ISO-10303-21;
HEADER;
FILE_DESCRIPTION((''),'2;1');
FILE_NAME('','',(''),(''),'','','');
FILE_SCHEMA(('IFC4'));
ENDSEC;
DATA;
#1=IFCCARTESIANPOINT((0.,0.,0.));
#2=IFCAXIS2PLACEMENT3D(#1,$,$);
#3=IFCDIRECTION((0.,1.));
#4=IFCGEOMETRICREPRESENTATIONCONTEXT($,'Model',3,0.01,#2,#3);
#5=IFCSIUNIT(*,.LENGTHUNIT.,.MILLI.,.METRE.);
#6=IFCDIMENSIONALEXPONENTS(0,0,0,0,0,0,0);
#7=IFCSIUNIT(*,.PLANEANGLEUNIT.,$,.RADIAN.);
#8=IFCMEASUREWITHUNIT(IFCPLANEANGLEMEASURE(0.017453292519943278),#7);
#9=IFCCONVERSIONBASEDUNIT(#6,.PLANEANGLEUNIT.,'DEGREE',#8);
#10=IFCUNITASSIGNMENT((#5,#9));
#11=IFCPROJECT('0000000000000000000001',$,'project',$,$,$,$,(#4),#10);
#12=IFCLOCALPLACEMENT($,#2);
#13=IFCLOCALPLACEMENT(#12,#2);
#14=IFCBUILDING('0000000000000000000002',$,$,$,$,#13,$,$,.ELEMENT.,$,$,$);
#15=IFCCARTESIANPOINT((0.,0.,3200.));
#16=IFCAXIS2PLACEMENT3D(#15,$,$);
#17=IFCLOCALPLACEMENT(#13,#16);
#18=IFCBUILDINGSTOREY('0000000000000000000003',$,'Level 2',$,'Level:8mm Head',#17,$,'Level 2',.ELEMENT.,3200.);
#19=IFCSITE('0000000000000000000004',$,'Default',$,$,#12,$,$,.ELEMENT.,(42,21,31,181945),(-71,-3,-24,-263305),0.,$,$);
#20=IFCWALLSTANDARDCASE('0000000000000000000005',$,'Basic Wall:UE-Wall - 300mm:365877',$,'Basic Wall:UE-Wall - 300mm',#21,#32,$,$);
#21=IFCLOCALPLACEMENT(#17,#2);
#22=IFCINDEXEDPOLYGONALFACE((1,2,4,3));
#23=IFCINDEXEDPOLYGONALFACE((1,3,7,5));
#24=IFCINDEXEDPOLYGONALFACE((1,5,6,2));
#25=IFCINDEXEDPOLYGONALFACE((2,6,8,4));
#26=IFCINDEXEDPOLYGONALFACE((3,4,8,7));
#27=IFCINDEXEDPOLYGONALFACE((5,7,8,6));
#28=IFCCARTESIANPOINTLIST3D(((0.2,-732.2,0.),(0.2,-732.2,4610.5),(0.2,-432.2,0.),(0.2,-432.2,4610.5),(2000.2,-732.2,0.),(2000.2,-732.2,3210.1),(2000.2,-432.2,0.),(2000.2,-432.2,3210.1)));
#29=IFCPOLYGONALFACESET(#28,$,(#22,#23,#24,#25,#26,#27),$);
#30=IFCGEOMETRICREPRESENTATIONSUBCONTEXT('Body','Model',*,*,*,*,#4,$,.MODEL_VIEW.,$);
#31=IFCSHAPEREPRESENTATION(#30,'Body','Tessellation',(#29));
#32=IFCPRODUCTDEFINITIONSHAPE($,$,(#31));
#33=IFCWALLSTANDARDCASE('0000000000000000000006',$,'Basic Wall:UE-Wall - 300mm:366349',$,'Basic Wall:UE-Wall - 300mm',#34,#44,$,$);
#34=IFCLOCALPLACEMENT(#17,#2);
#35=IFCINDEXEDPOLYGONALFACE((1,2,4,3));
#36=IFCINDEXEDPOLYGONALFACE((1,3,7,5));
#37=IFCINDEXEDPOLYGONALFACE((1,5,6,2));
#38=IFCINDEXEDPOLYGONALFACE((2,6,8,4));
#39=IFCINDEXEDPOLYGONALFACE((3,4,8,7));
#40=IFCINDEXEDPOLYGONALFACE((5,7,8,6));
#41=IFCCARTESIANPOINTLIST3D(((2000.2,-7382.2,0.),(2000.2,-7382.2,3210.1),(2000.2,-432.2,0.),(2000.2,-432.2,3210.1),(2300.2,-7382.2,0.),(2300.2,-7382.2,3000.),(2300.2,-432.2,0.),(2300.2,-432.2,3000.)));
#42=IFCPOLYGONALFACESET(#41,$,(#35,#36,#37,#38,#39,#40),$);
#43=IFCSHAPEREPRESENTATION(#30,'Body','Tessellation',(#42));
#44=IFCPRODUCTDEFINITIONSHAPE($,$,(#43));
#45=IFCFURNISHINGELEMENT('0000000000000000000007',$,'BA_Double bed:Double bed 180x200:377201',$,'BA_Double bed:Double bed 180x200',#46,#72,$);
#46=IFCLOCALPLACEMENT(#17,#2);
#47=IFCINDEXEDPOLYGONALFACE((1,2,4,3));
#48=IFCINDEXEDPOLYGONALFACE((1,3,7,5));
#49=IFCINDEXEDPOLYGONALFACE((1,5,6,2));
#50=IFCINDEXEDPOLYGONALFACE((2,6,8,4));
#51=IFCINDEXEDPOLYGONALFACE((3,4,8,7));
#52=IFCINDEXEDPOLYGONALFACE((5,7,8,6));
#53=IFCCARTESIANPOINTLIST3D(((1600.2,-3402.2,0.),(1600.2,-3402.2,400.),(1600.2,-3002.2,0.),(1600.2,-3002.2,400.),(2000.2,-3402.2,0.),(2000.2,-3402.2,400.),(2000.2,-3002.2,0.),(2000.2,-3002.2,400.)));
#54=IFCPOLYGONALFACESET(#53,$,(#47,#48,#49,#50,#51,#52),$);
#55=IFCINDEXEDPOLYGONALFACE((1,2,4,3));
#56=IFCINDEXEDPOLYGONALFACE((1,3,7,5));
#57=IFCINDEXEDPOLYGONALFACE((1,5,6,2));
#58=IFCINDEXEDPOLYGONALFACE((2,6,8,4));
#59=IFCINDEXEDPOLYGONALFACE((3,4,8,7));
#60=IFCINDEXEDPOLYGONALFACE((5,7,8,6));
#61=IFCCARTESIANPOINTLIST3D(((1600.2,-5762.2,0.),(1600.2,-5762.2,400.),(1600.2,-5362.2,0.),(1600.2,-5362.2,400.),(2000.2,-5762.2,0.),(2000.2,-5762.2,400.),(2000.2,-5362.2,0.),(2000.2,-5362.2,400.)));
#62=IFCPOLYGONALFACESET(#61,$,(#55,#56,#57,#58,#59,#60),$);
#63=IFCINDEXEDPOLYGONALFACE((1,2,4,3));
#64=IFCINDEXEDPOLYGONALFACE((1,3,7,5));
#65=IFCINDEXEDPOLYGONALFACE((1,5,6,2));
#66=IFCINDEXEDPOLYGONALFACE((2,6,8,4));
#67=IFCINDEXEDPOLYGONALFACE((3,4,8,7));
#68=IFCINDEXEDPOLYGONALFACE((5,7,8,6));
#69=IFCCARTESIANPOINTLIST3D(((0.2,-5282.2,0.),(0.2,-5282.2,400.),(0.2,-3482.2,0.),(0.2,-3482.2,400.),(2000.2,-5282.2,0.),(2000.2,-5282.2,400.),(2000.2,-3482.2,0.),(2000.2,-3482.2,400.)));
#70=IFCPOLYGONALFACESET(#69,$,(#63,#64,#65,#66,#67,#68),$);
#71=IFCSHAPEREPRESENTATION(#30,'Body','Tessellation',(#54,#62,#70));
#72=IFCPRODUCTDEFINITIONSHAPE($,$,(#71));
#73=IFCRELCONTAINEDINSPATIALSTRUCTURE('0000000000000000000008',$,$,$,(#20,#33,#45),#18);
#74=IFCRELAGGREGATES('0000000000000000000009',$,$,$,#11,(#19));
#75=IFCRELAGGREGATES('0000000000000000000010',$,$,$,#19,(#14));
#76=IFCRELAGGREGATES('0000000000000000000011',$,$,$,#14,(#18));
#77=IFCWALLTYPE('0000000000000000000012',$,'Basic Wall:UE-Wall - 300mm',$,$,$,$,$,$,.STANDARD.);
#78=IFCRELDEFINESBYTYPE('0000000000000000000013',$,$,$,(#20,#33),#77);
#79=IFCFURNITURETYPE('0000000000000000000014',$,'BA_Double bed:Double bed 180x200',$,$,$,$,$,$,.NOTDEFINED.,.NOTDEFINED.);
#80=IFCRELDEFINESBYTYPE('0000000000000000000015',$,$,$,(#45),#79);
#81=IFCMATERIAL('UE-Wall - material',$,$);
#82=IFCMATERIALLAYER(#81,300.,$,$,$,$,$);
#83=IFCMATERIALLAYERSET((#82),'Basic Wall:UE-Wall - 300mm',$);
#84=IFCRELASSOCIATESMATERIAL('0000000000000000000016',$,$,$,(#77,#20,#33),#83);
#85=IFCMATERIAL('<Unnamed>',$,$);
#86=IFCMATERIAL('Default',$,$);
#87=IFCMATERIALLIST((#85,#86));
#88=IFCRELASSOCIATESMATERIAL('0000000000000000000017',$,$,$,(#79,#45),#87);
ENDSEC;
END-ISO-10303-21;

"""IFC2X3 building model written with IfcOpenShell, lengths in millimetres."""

from ifc_helpers import new_model, entity, si_unit, converted_unit, direction, frame, frame_2d, origin, origin_2d_with_axis, place, context, subcontext, project, spatial, polyline, rectangle, extrude, clip, bounded_halfspace, source, transform, mapped, material, material_list, layer, layer_set, layer_usage, type_object, type_shapes, element, save


model = new_model("IFC2X3")

# Units and contexts
model_context = context("Model", 3, precision=0.01, world=origin(), true_north=direction((0.0, 1.0)))
body_context = subcontext(model_context, "Body", "Model", "MODEL_VIEW")
ifc_project = project(units=[si_unit("LENGTHUNIT", "METRE", prefix="MILLI"), converted_unit("PLANEANGLEUNIT", "DEGREE", entity("IfcPlaneAngleMeasure", 0.017453292519943278), si_unit("PLANEANGLEUNIT", "RADIAN"), dimensions=[0, 0, 0, 0, 0, 0, 0])], contexts=[model_context])

# Site, building, storey
site_placement = place(None, origin())
site = spatial("IfcSite", under=ifc_project, at=site_placement, Name="Default", CompositionType="ELEMENT", RefLatitude=(42, 21, 31, 181945), RefLongitude=(-71, -3, -24, -263305), RefElevation=0.0)
building_placement = place(site_placement, origin())
building = spatial("IfcBuilding", under=site, at=building_placement, CompositionType="ELEMENT")
storey_placement = place(building_placement, frame((0.0, 0.0, 3200.0)))
storey = spatial("IfcBuildingStorey", under=building, at=storey_placement, Name="Level 2", ObjectType="Level:8mm Head", LongName="Level 2", CompositionType="ELEMENT", Elevation=3200.0)

# Shared definitions
ifc_material_1 = material(Name="Default")

# Walls
ifc_material_2 = material(Name="UE-Wall - material")
ifc_layer_1 = layer(ifc_material_2, 300.0)
ifc_layer_set_1 = layer_set([ifc_layer_1], Name="Basic Wall:UE-Wall - 300mm")
ifc_layer_usage_1 = layer_usage(ifc_layer_set_1, "AXIS2", "NEGATIVE", 150.0)
wall_type_1 = type_object("IfcWallType", Name="Basic Wall:UE-Wall - 300mm", PredefinedType="STANDARD", material=ifc_layer_set_1)
wall_1_placement = place(storey_placement, frame((0.2, -582.2, 0.0)))
element("IfcWallStandardCase", 1, at=wall_1_placement, inside=storey, type_object=wall_type_1, material=ifc_layer_usage_1, Name="Basic Wall:UE-Wall - 300mm:365877", ObjectType="Basic Wall:UE-Wall - 300mm", context=body_context, shape_type="Clipping", body=[
    clip(extrude(rectangle(XDim=2000.0, YDim=300.0, at=frame_2d((1000.0, 0.0), x_axis=(-1.0, 0.0))), origin(), (0.0, 0.0, 1.0), 4610.5), bounded_halfspace(frame((0.0, -150.0, 4610.5), z_axis=(0.573576, 0.0, 0.819152), x_axis=(0.0, 1.0, 0.0)), False, frame((0.0, -150.0, 4610.5)), polyline([(0.0, 0.0), (2000.0, 0.0), (2000.0, 300.0), (225.0, 300.0), (150.0, 300.0), (0.0, 300.0), (0.0, 150.0), (0.0, 0.0)]))),
])
ifc_layer_usage_2 = layer_usage(ifc_layer_set_1, "AXIS2", "NEGATIVE", 150.0)
wall_2_placement = place(storey_placement, frame((2150.2, -432.2, 0.0), z_axis=(0.0, 0.0, 1.0), x_axis=(0.0, -1.0, 0.0)))
element("IfcWallStandardCase", 2, at=wall_2_placement, inside=storey, type_object=wall_type_1, material=ifc_layer_usage_2, Name="Basic Wall:UE-Wall - 300mm:366349", ObjectType="Basic Wall:UE-Wall - 300mm", context=body_context, shape_type="Clipping", body=[
    clip(extrude(rectangle(XDim=6950.0, YDim=300.0, at=frame_2d((3475.0, 0.0), x_axis=(-1.0, 0.0))), origin(), (0.0, 0.0, 1.0), 3210.1), bounded_halfspace(frame((0.0, -150.0, 3210.1), z_axis=(0.0, 0.573576, 0.819152), x_axis=(-1.0, 0.0, 0.0)), False, frame((0.0, -150.0, 3210.1)), polyline([(0.0, 0.0), (300.0, 0.0), (2250.0, 0.0), (2400.0, 0.0), (5500.0, 0.0), (5800.0, 0.0), (6950.0, 0.0), (6950.0, 300.0), (0.0, 300.0), (0.0, 0.0)]))),
])

# Furnishing element
ifc_material_3 = material(Name="<Unnamed>")
ifc_material_list = material_list([ifc_material_3, ifc_material_1])
furniture_type = type_object("IfcFurnitureType", Name="BA_Double bed:Double bed 180x200", AssemblyPlace="NOTDEFINED", material=ifc_material_list)
shared_shape_1 = source(origin(), body_context, "Body", "SweptSolid", [
    extrude(rectangle(XDim=400.0, YDim=400.0, at=frame_2d((0.0, 0.0), x_axis=(1.0, 0.0))), frame((-1180.0, 800.0, 0.0), z_axis=(0.0, 0.0, 1.0), x_axis=(0.0, -1.0, 0.0)), (0.0, 0.0, 1.0), 400.0),
    extrude(rectangle(XDim=400.0, YDim=400.0, at=origin_2d_with_axis()), frame((1180.0, 800.0, 0.0), z_axis=(0.0, 0.0, 1.0), x_axis=(-1.0, 0.0, 0.0)), (0.0, 0.0, 1.0), 400.0),
    extrude(rectangle(XDim=1800.0, YDim=2000.0, at=origin_2d_with_axis()), frame((0.0, 0.0, 0.0), z_axis=(0.0, 0.0, 1.0), x_axis=(-1.0, 0.0, 0.0)), (0.0, 0.0, 1.0), 400.0),
])
type_shapes(furniture_type, [shared_shape_1])
furnishing_placement = place(storey_placement, frame((1000.2, -4382.2, 0.0), z_axis=(0.0, 0.0, 1.0), x_axis=(0.0, -1.0, 0.0)))
element("IfcFurnishingElement", 3, at=furnishing_placement, inside=storey, type_object=furniture_type, material=ifc_material_list, Name="BA_Double bed:Double bed 180x200:377201", ObjectType="BA_Double bed:Double bed 180x200", context=body_context, shape_type="MappedRepresentation", body=[
    mapped(shared_shape_1, transform((0.0, 0.0, 0.0), scale=1.0)),
])

save(model, "model.ifc")
